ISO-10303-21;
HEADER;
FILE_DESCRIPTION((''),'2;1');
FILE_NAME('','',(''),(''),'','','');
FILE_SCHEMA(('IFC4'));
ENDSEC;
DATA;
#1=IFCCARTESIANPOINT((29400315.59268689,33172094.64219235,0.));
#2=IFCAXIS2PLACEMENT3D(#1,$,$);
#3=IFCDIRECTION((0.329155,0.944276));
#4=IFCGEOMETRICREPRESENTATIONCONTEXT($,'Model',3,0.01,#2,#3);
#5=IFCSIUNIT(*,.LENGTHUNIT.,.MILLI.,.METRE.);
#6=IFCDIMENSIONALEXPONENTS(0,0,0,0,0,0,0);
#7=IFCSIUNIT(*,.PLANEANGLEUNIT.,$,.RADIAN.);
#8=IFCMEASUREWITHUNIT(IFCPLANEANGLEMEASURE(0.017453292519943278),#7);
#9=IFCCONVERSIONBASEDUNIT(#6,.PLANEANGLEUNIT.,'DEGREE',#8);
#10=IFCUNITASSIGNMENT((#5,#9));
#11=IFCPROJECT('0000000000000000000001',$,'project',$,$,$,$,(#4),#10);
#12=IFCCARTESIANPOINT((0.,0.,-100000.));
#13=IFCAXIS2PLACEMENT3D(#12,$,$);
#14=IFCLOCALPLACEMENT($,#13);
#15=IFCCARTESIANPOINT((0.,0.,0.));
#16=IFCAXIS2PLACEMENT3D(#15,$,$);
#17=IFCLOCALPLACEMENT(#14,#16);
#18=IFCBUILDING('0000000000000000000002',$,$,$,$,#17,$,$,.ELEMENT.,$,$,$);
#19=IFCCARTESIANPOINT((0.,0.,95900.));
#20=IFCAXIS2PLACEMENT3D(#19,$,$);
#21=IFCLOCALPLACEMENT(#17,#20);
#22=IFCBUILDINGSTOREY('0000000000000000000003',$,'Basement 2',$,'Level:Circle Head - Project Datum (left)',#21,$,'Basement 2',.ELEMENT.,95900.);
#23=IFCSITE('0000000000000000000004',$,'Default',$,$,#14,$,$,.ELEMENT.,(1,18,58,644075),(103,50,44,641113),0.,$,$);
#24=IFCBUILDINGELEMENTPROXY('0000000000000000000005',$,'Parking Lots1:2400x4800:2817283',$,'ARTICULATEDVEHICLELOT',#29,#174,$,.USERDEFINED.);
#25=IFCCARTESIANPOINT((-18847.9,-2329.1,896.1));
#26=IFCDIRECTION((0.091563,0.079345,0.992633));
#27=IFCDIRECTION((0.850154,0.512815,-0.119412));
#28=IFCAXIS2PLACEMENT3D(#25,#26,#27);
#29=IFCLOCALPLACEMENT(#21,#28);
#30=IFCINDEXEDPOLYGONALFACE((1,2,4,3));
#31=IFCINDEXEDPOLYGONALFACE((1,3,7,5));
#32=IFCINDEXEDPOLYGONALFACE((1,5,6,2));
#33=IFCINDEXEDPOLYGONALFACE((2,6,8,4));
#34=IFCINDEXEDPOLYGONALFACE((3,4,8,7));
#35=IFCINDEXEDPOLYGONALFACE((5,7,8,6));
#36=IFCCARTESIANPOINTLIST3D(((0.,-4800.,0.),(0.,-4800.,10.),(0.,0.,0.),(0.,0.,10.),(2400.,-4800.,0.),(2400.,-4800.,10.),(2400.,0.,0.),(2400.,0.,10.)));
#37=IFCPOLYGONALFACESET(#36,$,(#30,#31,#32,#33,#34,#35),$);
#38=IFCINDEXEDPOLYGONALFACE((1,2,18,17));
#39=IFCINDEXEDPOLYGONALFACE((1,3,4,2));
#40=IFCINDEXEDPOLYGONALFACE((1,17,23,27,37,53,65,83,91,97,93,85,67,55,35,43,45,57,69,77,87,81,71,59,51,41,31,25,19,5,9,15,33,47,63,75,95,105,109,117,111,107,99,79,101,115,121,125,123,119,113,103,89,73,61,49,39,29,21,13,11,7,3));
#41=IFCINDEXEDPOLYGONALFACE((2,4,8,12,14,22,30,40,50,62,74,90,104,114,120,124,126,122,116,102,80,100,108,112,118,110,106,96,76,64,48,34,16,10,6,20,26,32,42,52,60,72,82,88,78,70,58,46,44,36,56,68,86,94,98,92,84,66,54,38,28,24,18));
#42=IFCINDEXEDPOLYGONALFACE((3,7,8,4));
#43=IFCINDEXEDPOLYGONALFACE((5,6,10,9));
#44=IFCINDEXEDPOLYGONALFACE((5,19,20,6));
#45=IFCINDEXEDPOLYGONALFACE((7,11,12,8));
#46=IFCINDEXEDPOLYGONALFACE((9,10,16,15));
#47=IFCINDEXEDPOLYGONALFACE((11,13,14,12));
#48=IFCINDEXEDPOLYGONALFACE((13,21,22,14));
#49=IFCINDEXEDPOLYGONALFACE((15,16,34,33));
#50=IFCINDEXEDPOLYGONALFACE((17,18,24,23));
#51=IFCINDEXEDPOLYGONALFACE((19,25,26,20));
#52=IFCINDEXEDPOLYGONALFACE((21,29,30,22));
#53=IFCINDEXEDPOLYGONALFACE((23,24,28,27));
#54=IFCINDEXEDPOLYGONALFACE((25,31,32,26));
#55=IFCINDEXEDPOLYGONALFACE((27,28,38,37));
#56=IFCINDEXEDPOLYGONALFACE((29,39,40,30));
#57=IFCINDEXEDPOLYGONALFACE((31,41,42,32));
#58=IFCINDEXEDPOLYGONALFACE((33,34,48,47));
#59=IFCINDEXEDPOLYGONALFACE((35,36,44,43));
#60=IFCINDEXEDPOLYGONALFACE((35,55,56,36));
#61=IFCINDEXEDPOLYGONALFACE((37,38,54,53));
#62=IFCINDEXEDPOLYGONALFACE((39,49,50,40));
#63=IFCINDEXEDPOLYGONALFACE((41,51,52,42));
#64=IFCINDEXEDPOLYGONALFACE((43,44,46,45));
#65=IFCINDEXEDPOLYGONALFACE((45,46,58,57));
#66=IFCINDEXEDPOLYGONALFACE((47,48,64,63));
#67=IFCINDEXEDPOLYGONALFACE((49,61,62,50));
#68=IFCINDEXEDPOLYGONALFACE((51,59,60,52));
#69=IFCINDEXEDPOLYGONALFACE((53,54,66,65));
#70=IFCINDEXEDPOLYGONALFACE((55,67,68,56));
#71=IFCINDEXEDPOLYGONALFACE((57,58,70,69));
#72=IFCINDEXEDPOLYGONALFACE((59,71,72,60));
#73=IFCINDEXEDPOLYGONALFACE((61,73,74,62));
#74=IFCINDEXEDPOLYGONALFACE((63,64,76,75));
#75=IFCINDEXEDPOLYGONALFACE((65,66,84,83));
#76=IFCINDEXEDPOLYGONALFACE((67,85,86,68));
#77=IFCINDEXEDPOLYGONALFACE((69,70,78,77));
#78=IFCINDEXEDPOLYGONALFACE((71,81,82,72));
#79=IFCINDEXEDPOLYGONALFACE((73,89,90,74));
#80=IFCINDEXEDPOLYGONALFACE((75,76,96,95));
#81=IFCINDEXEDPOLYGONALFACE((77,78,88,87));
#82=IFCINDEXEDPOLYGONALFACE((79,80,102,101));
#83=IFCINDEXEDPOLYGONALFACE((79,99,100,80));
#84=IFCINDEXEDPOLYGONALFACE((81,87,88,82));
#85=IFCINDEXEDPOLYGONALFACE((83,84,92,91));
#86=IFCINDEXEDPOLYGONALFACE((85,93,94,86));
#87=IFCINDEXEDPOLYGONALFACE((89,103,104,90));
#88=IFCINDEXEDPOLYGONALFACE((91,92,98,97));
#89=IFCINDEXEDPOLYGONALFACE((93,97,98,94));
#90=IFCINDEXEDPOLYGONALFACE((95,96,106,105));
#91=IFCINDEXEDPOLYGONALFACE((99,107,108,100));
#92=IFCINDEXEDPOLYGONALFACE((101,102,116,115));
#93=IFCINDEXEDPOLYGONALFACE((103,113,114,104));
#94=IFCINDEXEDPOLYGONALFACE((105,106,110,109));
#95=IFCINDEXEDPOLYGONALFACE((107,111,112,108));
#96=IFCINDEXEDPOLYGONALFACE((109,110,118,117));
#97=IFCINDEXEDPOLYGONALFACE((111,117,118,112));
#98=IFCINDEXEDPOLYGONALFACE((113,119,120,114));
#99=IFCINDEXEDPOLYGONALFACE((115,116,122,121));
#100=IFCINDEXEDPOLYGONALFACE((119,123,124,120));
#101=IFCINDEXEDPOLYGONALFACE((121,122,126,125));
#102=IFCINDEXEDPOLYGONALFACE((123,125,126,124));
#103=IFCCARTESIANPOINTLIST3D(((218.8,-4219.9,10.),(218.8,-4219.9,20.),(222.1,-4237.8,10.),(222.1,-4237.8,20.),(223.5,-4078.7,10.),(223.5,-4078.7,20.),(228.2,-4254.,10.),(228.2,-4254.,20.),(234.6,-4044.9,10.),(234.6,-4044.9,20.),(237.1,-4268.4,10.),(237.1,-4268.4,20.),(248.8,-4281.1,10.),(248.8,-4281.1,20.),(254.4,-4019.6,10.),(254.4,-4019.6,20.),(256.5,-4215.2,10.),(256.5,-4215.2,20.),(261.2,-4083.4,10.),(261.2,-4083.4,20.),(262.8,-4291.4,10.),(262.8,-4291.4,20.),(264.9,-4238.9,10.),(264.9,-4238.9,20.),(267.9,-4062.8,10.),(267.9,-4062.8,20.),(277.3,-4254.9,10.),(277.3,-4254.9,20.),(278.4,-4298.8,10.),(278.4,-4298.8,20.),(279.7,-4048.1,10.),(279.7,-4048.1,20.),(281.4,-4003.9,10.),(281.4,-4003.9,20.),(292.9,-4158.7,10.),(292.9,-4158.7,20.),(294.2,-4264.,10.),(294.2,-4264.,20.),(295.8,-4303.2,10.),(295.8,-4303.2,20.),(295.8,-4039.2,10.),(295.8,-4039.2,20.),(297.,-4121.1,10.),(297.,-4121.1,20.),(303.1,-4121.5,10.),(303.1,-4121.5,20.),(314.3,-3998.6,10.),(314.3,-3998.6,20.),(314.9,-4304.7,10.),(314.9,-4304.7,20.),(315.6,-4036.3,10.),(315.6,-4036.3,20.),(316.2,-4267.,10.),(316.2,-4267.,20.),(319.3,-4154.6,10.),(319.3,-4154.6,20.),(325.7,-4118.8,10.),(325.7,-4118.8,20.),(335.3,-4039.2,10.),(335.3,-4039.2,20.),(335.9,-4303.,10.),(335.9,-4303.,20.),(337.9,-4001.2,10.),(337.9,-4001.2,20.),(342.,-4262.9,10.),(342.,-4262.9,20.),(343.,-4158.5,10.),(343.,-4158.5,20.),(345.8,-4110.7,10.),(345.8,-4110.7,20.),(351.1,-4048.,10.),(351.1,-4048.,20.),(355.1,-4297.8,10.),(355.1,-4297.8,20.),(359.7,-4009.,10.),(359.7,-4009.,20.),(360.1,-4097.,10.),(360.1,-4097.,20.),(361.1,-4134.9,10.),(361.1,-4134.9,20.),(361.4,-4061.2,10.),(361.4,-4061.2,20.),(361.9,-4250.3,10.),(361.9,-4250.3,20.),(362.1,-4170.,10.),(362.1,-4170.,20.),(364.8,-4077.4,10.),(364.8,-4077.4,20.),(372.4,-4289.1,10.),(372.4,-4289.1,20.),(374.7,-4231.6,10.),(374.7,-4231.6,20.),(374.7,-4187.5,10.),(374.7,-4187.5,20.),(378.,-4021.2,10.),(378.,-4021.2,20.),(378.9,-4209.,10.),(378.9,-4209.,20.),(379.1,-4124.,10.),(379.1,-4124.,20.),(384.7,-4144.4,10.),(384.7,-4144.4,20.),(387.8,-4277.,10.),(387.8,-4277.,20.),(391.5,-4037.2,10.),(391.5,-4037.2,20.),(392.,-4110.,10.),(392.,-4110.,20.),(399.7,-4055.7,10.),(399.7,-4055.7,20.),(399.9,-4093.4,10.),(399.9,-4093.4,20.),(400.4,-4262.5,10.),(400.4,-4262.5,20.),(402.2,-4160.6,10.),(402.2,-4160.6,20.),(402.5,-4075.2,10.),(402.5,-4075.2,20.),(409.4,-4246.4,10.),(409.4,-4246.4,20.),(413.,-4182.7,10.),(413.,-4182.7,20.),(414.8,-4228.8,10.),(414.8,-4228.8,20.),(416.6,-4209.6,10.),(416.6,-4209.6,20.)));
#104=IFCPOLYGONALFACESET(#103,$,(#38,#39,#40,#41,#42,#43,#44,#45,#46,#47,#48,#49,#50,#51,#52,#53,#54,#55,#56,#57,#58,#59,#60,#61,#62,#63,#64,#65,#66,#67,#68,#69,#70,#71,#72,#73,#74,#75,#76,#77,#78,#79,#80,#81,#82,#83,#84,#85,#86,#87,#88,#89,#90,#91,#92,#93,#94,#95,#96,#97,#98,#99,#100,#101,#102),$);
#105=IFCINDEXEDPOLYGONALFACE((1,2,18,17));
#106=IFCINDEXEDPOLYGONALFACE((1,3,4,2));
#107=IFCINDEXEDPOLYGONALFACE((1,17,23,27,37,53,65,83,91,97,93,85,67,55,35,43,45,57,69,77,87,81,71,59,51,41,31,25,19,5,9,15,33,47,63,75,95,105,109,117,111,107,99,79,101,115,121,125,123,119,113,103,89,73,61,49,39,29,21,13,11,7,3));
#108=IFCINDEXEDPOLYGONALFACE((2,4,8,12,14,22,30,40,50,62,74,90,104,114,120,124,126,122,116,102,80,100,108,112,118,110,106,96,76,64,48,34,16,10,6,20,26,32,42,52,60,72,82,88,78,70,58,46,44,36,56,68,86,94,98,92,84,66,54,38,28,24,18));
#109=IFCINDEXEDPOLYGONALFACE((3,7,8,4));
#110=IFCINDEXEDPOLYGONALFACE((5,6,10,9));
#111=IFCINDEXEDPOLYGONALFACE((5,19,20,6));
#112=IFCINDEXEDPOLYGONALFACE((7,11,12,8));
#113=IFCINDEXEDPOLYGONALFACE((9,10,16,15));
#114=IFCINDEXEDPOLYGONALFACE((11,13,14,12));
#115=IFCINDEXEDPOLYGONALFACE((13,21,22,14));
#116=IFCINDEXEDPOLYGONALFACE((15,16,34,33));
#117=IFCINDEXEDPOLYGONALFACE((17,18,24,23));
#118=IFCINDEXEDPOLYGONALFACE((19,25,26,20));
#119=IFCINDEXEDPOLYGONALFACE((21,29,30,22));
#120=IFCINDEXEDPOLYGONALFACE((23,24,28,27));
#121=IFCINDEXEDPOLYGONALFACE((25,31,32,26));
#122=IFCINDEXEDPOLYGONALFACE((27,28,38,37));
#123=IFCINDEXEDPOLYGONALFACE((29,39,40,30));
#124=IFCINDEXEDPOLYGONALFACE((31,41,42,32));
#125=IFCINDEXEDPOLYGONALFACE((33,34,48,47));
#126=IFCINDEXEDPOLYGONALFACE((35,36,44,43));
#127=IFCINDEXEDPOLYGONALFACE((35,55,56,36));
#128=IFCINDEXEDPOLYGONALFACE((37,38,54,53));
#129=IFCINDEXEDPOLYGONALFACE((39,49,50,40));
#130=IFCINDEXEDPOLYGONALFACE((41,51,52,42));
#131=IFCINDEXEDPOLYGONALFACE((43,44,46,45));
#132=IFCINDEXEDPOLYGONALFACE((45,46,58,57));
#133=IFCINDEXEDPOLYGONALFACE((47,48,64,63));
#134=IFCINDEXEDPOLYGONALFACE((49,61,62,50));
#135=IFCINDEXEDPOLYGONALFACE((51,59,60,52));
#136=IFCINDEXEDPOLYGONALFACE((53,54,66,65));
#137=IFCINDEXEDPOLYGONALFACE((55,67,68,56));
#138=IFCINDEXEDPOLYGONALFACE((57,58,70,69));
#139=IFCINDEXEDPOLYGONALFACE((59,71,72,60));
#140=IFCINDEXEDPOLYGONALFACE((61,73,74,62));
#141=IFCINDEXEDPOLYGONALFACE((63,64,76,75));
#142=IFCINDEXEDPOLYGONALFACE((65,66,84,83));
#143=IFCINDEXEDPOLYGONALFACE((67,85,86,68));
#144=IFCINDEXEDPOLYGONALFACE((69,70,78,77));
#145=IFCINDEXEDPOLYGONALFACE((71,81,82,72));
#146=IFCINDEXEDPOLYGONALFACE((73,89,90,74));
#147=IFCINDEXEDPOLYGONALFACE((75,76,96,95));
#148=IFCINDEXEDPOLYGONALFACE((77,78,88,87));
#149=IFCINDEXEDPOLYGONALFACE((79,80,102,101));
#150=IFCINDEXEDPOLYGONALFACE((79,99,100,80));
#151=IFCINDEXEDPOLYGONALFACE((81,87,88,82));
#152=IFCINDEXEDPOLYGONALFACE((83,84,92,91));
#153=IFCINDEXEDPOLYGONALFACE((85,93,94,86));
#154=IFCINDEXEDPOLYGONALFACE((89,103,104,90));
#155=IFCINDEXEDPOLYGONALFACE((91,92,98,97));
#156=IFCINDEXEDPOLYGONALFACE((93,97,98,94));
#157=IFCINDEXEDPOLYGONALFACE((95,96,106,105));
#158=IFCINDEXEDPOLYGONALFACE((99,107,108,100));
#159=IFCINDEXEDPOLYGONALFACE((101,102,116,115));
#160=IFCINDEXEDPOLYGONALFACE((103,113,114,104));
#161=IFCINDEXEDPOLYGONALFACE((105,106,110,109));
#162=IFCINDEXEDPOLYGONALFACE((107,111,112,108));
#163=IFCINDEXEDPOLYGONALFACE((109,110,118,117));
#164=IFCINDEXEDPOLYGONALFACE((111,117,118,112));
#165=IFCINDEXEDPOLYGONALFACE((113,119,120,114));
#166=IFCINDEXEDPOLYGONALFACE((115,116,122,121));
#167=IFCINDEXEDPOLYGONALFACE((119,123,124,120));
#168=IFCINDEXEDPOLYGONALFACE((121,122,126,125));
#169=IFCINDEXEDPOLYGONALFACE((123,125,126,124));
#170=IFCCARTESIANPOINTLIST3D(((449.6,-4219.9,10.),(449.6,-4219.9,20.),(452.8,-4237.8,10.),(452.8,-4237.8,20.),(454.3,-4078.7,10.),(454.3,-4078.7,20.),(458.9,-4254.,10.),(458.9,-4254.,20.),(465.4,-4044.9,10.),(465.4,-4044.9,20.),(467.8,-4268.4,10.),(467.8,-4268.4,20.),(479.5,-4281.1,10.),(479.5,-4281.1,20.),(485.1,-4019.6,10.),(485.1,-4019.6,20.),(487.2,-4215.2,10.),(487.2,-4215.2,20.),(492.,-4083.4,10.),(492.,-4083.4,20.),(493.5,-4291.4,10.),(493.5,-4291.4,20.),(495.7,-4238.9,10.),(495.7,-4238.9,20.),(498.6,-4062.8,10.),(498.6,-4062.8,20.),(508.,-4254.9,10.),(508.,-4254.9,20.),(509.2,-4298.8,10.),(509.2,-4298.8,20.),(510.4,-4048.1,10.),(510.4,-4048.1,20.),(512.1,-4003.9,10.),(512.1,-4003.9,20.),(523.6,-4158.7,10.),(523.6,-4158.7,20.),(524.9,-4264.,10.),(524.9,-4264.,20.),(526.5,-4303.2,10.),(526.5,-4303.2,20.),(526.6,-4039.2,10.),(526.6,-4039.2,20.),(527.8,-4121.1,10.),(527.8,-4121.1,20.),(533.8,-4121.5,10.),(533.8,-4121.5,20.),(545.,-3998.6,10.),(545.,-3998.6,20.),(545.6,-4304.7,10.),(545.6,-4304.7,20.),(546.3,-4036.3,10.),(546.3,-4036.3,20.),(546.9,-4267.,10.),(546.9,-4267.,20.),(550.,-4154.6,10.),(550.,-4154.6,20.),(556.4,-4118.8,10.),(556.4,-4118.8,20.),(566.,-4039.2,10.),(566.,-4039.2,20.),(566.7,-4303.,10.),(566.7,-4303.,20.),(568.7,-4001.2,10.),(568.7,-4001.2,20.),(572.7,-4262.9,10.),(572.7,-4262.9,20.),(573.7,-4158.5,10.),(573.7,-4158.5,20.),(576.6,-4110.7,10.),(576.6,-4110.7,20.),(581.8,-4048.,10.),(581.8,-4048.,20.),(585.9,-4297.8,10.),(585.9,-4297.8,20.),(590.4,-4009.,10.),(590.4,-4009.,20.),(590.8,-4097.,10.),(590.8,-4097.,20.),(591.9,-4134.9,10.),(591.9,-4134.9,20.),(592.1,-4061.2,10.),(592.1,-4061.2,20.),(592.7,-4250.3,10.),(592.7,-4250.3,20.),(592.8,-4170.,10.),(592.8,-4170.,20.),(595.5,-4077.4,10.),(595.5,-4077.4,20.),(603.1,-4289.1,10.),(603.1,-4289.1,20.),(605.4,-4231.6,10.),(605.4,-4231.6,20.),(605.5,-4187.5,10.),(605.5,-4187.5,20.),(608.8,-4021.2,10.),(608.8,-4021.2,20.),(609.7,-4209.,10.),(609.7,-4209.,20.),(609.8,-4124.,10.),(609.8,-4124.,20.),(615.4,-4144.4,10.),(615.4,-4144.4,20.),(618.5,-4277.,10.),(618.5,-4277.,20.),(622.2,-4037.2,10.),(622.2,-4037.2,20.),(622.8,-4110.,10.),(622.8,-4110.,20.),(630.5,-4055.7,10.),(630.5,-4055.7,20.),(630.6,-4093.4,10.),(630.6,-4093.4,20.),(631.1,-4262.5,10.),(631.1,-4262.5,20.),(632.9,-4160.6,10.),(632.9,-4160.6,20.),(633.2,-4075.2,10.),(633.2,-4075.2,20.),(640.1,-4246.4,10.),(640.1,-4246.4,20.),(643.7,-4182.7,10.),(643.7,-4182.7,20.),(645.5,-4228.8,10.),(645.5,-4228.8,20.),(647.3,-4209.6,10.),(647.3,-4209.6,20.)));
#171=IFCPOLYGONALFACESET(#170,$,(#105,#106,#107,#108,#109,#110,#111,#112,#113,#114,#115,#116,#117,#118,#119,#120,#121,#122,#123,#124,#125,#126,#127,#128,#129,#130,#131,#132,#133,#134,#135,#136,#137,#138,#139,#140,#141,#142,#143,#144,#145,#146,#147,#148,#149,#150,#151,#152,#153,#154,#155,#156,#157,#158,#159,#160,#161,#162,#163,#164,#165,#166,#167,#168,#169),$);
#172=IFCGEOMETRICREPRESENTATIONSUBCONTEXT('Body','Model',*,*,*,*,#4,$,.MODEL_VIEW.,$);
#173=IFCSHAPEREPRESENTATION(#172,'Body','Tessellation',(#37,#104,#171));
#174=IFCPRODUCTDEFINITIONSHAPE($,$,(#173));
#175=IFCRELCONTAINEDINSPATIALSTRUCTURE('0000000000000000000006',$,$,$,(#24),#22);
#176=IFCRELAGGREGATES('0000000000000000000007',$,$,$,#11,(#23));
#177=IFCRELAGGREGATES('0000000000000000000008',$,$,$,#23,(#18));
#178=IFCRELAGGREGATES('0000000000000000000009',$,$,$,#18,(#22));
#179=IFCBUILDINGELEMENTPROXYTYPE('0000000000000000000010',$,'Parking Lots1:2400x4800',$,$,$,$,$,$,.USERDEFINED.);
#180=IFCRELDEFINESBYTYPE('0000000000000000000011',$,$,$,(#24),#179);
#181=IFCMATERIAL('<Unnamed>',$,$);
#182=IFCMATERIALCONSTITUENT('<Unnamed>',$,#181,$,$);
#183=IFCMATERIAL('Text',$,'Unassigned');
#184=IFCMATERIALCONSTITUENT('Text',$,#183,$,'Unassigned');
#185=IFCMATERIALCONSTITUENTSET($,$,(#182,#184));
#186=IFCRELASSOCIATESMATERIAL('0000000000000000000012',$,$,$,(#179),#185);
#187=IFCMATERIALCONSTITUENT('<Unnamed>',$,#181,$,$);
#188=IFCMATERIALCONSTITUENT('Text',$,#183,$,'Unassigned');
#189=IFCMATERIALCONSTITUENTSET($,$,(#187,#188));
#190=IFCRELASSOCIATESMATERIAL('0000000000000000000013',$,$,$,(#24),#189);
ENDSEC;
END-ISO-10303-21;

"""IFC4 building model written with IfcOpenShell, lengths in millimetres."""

from ifc_helpers import new_model, entity, si_unit, converted_unit, direction, frame, origin, place, context, subcontext, project, spatial, indexed_curve, outline, extrude, source, transform, mapped, material, constituent, constituent_set, type_object, type_shapes, element, save


model = new_model("IFC4")

# Units and contexts
model_context = context("Model", 3, precision=0.01, world=frame((29400315.59268689, 33172094.64219235, 0.0)), true_north=direction((0.329155, 0.944276)))
body_context = subcontext(model_context, "Body", "Model", "MODEL_VIEW")
ifc_project = project(units=[si_unit("LENGTHUNIT", "METRE", prefix="MILLI"), converted_unit("PLANEANGLEUNIT", "DEGREE", entity("IfcPlaneAngleMeasure", 0.017453292519943278), si_unit("PLANEANGLEUNIT", "RADIAN"), dimensions=[0, 0, 0, 0, 0, 0, 0])], contexts=[model_context])

# Site, building, storey
site_placement = place(None, frame((0.0, 0.0, -100000.0)))
site = spatial("IfcSite", under=ifc_project, at=site_placement, Name="Default", CompositionType="ELEMENT", RefLatitude=(1, 18, 58, 644075), RefLongitude=(103, 50, 44, 641113), RefElevation=0.0)
building_placement = place(site_placement, origin())
building = spatial("IfcBuilding", under=site, at=building_placement, CompositionType="ELEMENT")
storey_placement = place(building_placement, frame((0.0, 0.0, 95900.0)))
storey = spatial("IfcBuildingStorey", under=building, at=storey_placement, Name="Basement 2", ObjectType="Level:Circle Head - Project Datum (left)", LongName="Basement 2", CompositionType="ELEMENT", Elevation=95900.0)

# Shared definitions
ifc_material_1 = material(Name="<Unnamed>")

# Building element proxy
ifc_material_2 = material(Name="Text", Category="Unassigned")
ifc_constituent_1 = constituent(ifc_material_1, Name="<Unnamed>")
ifc_constituent_2 = constituent(ifc_material_2, Name="Text", Category="Unassigned")
ifc_constituent_set_1 = constituent_set(constituents=[ifc_constituent_1, ifc_constituent_2])
ifc_constituent_3 = constituent(ifc_material_1, Name="<Unnamed>")
ifc_constituent_4 = constituent(ifc_material_2, Name="Text", Category="Unassigned")
ifc_constituent_set_2 = constituent_set(constituents=[ifc_constituent_3, ifc_constituent_4])
building_element_proxy_type_1 = type_object("IfcBuildingElementProxyType", Name="Parking Lots1:2400x4800", PredefinedType="USERDEFINED", material=ifc_constituent_set_2)
shared_shape_1 = source(origin(), body_context, "Body", "SweptSolid", [
    extrude(outline(indexed_curve([(-1200.0, -2400.0), (1200.0, -2400.0), (1200.0, 2400.0), (-1200.0, 2400.0), (-1200.0, -2400.0)], self_intersect=False)), frame((1200.0, -2400.0, 0.0), z_axis=(0.0, 0.0, 1.0), x_axis=(-1.0, 0.0, 0.0)), (0.0, 0.0, 1.0), 10.0),
    extrude(outline(indexed_curve([(41.2, -119.5), (59.4, -119.5), (76.4, -116.4), (92.1, -110.3), (106.7, -101.0), (119.4, -89.1), (129.4, -75.0), (136.9, -58.7), (141.8, -40.2), (143.8, -19.2), (142.2, 0.6), (136.7, 19.2), (127.6, 36.5), (115.5, 51.5), (101.3, 63.2), (84.9, 71.7), (66.4, 76.9), (39.2, 78.2), (15.6, 71.5), (-3.5, 57.2), (-17.0, 35.7), (-24.5, 55.3), (-36.1, 70.5), (-50.9, 81.2), (-68.4, 87.0), (-88.1, 87.8), (-107.7, 83.0), (-125.9, 72.6), (-141.2, 56.8), (-152.7, 36.8), (-159.5, 13.9), (-160.2, -19.4), (-149.6, -48.7), (-128.2, -72.7), (-96.9, -89.6), (-85.6, -53.4), (-104.7, -43.2), (-117.0, -28.9), (-122.8, -11.5), (-122.2, 8.5), (-115.8, 27.4), (-104.4, 41.3), (-89.5, 49.1), (-72.9, 49.6), (-54.6, 41.4), (-43.6, 24.9), (-39.2, 3.6), (-40.6, -19.0), (-42.1, -24.9), (-5.8, -35.8), (-5.1, -9.0), (2.9, 13.6), (17.7, 30.3), (37.1, 39.7), (59.0, 40.0), (80.6, 31.7), (96.7, 15.8), (105.4, -6.0), (104.9, -32.2), (98.0, -53.3), (86.0, -68.3), (68.1, -77.6), (43.3, -81.6), (41.2, -119.5)], self_intersect=False)), frame((329.1, -4158.0, 10.0), z_axis=(0.0, 0.0, 1.0), x_axis=(0.178774, -0.98389, 0.0)), (0.0, 0.0, 1.0), 10.0),
    extrude(outline(indexed_curve([(41.2, -119.5), (59.4, -119.5), (76.4, -116.4), (92.1, -110.3), (106.7, -101.0), (119.4, -89.1), (129.4, -75.0), (136.9, -58.7), (141.8, -40.2), (143.8, -19.2), (142.2, 0.6), (136.7, 19.2), (127.6, 36.5), (115.5, 51.5), (101.3, 63.2), (84.9, 71.7), (66.4, 76.9), (39.2, 78.2), (15.6, 71.5), (-3.5, 57.2), (-17.0, 35.7), (-24.5, 55.3), (-36.1, 70.5), (-50.9, 81.2), (-68.4, 87.0), (-88.1, 87.8), (-107.7, 83.0), (-125.9, 72.6), (-141.2, 56.8), (-152.7, 36.8), (-159.5, 13.9), (-160.2, -19.4), (-149.6, -48.7), (-128.2, -72.7), (-96.9, -89.6), (-85.6, -53.4), (-104.7, -43.2), (-117.0, -28.9), (-122.8, -11.5), (-122.2, 8.5), (-115.8, 27.4), (-104.4, 41.3), (-89.5, 49.1), (-72.9, 49.6), (-54.6, 41.4), (-43.6, 24.9), (-39.2, 3.6), (-40.6, -19.0), (-42.1, -24.9), (-5.8, -35.8), (-5.1, -9.0), (2.9, 13.6), (17.7, 30.3), (37.1, 39.7), (59.0, 40.0), (80.6, 31.7), (96.7, 15.8), (105.4, -6.0), (104.9, -32.2), (98.0, -53.3), (86.0, -68.3), (68.1, -77.6), (43.3, -81.6), (41.2, -119.5)], self_intersect=False)), frame((559.8, -4158.0, 10.0), z_axis=(0.0, 0.0, 1.0), x_axis=(0.178774, -0.98389, 0.0)), (0.0, 0.0, 1.0), 10.0),
])
type_shapes(building_element_proxy_type_1, [shared_shape_1])
proxy_1_placement = place(storey_placement, frame((-18847.9, -2329.1, 896.1), z_axis=(0.091563, 0.079345, 0.992633), x_axis=(0.850154, 0.512815, -0.119412)))
element("IfcBuildingElementProxy", 1, at=proxy_1_placement, inside=storey, type_object=building_element_proxy_type_1, material=ifc_constituent_set_1, Name="Parking Lots1:2400x4800:2817283", ObjectType="ARTICULATEDVEHICLELOT", PredefinedType="USERDEFINED", context=body_context, shape_type="MappedRepresentation", body=[
    mapped(shared_shape_1, transform((0.0, 0.0, 0.0), scale=1.0)),
])

save(model, "model.ifc")
